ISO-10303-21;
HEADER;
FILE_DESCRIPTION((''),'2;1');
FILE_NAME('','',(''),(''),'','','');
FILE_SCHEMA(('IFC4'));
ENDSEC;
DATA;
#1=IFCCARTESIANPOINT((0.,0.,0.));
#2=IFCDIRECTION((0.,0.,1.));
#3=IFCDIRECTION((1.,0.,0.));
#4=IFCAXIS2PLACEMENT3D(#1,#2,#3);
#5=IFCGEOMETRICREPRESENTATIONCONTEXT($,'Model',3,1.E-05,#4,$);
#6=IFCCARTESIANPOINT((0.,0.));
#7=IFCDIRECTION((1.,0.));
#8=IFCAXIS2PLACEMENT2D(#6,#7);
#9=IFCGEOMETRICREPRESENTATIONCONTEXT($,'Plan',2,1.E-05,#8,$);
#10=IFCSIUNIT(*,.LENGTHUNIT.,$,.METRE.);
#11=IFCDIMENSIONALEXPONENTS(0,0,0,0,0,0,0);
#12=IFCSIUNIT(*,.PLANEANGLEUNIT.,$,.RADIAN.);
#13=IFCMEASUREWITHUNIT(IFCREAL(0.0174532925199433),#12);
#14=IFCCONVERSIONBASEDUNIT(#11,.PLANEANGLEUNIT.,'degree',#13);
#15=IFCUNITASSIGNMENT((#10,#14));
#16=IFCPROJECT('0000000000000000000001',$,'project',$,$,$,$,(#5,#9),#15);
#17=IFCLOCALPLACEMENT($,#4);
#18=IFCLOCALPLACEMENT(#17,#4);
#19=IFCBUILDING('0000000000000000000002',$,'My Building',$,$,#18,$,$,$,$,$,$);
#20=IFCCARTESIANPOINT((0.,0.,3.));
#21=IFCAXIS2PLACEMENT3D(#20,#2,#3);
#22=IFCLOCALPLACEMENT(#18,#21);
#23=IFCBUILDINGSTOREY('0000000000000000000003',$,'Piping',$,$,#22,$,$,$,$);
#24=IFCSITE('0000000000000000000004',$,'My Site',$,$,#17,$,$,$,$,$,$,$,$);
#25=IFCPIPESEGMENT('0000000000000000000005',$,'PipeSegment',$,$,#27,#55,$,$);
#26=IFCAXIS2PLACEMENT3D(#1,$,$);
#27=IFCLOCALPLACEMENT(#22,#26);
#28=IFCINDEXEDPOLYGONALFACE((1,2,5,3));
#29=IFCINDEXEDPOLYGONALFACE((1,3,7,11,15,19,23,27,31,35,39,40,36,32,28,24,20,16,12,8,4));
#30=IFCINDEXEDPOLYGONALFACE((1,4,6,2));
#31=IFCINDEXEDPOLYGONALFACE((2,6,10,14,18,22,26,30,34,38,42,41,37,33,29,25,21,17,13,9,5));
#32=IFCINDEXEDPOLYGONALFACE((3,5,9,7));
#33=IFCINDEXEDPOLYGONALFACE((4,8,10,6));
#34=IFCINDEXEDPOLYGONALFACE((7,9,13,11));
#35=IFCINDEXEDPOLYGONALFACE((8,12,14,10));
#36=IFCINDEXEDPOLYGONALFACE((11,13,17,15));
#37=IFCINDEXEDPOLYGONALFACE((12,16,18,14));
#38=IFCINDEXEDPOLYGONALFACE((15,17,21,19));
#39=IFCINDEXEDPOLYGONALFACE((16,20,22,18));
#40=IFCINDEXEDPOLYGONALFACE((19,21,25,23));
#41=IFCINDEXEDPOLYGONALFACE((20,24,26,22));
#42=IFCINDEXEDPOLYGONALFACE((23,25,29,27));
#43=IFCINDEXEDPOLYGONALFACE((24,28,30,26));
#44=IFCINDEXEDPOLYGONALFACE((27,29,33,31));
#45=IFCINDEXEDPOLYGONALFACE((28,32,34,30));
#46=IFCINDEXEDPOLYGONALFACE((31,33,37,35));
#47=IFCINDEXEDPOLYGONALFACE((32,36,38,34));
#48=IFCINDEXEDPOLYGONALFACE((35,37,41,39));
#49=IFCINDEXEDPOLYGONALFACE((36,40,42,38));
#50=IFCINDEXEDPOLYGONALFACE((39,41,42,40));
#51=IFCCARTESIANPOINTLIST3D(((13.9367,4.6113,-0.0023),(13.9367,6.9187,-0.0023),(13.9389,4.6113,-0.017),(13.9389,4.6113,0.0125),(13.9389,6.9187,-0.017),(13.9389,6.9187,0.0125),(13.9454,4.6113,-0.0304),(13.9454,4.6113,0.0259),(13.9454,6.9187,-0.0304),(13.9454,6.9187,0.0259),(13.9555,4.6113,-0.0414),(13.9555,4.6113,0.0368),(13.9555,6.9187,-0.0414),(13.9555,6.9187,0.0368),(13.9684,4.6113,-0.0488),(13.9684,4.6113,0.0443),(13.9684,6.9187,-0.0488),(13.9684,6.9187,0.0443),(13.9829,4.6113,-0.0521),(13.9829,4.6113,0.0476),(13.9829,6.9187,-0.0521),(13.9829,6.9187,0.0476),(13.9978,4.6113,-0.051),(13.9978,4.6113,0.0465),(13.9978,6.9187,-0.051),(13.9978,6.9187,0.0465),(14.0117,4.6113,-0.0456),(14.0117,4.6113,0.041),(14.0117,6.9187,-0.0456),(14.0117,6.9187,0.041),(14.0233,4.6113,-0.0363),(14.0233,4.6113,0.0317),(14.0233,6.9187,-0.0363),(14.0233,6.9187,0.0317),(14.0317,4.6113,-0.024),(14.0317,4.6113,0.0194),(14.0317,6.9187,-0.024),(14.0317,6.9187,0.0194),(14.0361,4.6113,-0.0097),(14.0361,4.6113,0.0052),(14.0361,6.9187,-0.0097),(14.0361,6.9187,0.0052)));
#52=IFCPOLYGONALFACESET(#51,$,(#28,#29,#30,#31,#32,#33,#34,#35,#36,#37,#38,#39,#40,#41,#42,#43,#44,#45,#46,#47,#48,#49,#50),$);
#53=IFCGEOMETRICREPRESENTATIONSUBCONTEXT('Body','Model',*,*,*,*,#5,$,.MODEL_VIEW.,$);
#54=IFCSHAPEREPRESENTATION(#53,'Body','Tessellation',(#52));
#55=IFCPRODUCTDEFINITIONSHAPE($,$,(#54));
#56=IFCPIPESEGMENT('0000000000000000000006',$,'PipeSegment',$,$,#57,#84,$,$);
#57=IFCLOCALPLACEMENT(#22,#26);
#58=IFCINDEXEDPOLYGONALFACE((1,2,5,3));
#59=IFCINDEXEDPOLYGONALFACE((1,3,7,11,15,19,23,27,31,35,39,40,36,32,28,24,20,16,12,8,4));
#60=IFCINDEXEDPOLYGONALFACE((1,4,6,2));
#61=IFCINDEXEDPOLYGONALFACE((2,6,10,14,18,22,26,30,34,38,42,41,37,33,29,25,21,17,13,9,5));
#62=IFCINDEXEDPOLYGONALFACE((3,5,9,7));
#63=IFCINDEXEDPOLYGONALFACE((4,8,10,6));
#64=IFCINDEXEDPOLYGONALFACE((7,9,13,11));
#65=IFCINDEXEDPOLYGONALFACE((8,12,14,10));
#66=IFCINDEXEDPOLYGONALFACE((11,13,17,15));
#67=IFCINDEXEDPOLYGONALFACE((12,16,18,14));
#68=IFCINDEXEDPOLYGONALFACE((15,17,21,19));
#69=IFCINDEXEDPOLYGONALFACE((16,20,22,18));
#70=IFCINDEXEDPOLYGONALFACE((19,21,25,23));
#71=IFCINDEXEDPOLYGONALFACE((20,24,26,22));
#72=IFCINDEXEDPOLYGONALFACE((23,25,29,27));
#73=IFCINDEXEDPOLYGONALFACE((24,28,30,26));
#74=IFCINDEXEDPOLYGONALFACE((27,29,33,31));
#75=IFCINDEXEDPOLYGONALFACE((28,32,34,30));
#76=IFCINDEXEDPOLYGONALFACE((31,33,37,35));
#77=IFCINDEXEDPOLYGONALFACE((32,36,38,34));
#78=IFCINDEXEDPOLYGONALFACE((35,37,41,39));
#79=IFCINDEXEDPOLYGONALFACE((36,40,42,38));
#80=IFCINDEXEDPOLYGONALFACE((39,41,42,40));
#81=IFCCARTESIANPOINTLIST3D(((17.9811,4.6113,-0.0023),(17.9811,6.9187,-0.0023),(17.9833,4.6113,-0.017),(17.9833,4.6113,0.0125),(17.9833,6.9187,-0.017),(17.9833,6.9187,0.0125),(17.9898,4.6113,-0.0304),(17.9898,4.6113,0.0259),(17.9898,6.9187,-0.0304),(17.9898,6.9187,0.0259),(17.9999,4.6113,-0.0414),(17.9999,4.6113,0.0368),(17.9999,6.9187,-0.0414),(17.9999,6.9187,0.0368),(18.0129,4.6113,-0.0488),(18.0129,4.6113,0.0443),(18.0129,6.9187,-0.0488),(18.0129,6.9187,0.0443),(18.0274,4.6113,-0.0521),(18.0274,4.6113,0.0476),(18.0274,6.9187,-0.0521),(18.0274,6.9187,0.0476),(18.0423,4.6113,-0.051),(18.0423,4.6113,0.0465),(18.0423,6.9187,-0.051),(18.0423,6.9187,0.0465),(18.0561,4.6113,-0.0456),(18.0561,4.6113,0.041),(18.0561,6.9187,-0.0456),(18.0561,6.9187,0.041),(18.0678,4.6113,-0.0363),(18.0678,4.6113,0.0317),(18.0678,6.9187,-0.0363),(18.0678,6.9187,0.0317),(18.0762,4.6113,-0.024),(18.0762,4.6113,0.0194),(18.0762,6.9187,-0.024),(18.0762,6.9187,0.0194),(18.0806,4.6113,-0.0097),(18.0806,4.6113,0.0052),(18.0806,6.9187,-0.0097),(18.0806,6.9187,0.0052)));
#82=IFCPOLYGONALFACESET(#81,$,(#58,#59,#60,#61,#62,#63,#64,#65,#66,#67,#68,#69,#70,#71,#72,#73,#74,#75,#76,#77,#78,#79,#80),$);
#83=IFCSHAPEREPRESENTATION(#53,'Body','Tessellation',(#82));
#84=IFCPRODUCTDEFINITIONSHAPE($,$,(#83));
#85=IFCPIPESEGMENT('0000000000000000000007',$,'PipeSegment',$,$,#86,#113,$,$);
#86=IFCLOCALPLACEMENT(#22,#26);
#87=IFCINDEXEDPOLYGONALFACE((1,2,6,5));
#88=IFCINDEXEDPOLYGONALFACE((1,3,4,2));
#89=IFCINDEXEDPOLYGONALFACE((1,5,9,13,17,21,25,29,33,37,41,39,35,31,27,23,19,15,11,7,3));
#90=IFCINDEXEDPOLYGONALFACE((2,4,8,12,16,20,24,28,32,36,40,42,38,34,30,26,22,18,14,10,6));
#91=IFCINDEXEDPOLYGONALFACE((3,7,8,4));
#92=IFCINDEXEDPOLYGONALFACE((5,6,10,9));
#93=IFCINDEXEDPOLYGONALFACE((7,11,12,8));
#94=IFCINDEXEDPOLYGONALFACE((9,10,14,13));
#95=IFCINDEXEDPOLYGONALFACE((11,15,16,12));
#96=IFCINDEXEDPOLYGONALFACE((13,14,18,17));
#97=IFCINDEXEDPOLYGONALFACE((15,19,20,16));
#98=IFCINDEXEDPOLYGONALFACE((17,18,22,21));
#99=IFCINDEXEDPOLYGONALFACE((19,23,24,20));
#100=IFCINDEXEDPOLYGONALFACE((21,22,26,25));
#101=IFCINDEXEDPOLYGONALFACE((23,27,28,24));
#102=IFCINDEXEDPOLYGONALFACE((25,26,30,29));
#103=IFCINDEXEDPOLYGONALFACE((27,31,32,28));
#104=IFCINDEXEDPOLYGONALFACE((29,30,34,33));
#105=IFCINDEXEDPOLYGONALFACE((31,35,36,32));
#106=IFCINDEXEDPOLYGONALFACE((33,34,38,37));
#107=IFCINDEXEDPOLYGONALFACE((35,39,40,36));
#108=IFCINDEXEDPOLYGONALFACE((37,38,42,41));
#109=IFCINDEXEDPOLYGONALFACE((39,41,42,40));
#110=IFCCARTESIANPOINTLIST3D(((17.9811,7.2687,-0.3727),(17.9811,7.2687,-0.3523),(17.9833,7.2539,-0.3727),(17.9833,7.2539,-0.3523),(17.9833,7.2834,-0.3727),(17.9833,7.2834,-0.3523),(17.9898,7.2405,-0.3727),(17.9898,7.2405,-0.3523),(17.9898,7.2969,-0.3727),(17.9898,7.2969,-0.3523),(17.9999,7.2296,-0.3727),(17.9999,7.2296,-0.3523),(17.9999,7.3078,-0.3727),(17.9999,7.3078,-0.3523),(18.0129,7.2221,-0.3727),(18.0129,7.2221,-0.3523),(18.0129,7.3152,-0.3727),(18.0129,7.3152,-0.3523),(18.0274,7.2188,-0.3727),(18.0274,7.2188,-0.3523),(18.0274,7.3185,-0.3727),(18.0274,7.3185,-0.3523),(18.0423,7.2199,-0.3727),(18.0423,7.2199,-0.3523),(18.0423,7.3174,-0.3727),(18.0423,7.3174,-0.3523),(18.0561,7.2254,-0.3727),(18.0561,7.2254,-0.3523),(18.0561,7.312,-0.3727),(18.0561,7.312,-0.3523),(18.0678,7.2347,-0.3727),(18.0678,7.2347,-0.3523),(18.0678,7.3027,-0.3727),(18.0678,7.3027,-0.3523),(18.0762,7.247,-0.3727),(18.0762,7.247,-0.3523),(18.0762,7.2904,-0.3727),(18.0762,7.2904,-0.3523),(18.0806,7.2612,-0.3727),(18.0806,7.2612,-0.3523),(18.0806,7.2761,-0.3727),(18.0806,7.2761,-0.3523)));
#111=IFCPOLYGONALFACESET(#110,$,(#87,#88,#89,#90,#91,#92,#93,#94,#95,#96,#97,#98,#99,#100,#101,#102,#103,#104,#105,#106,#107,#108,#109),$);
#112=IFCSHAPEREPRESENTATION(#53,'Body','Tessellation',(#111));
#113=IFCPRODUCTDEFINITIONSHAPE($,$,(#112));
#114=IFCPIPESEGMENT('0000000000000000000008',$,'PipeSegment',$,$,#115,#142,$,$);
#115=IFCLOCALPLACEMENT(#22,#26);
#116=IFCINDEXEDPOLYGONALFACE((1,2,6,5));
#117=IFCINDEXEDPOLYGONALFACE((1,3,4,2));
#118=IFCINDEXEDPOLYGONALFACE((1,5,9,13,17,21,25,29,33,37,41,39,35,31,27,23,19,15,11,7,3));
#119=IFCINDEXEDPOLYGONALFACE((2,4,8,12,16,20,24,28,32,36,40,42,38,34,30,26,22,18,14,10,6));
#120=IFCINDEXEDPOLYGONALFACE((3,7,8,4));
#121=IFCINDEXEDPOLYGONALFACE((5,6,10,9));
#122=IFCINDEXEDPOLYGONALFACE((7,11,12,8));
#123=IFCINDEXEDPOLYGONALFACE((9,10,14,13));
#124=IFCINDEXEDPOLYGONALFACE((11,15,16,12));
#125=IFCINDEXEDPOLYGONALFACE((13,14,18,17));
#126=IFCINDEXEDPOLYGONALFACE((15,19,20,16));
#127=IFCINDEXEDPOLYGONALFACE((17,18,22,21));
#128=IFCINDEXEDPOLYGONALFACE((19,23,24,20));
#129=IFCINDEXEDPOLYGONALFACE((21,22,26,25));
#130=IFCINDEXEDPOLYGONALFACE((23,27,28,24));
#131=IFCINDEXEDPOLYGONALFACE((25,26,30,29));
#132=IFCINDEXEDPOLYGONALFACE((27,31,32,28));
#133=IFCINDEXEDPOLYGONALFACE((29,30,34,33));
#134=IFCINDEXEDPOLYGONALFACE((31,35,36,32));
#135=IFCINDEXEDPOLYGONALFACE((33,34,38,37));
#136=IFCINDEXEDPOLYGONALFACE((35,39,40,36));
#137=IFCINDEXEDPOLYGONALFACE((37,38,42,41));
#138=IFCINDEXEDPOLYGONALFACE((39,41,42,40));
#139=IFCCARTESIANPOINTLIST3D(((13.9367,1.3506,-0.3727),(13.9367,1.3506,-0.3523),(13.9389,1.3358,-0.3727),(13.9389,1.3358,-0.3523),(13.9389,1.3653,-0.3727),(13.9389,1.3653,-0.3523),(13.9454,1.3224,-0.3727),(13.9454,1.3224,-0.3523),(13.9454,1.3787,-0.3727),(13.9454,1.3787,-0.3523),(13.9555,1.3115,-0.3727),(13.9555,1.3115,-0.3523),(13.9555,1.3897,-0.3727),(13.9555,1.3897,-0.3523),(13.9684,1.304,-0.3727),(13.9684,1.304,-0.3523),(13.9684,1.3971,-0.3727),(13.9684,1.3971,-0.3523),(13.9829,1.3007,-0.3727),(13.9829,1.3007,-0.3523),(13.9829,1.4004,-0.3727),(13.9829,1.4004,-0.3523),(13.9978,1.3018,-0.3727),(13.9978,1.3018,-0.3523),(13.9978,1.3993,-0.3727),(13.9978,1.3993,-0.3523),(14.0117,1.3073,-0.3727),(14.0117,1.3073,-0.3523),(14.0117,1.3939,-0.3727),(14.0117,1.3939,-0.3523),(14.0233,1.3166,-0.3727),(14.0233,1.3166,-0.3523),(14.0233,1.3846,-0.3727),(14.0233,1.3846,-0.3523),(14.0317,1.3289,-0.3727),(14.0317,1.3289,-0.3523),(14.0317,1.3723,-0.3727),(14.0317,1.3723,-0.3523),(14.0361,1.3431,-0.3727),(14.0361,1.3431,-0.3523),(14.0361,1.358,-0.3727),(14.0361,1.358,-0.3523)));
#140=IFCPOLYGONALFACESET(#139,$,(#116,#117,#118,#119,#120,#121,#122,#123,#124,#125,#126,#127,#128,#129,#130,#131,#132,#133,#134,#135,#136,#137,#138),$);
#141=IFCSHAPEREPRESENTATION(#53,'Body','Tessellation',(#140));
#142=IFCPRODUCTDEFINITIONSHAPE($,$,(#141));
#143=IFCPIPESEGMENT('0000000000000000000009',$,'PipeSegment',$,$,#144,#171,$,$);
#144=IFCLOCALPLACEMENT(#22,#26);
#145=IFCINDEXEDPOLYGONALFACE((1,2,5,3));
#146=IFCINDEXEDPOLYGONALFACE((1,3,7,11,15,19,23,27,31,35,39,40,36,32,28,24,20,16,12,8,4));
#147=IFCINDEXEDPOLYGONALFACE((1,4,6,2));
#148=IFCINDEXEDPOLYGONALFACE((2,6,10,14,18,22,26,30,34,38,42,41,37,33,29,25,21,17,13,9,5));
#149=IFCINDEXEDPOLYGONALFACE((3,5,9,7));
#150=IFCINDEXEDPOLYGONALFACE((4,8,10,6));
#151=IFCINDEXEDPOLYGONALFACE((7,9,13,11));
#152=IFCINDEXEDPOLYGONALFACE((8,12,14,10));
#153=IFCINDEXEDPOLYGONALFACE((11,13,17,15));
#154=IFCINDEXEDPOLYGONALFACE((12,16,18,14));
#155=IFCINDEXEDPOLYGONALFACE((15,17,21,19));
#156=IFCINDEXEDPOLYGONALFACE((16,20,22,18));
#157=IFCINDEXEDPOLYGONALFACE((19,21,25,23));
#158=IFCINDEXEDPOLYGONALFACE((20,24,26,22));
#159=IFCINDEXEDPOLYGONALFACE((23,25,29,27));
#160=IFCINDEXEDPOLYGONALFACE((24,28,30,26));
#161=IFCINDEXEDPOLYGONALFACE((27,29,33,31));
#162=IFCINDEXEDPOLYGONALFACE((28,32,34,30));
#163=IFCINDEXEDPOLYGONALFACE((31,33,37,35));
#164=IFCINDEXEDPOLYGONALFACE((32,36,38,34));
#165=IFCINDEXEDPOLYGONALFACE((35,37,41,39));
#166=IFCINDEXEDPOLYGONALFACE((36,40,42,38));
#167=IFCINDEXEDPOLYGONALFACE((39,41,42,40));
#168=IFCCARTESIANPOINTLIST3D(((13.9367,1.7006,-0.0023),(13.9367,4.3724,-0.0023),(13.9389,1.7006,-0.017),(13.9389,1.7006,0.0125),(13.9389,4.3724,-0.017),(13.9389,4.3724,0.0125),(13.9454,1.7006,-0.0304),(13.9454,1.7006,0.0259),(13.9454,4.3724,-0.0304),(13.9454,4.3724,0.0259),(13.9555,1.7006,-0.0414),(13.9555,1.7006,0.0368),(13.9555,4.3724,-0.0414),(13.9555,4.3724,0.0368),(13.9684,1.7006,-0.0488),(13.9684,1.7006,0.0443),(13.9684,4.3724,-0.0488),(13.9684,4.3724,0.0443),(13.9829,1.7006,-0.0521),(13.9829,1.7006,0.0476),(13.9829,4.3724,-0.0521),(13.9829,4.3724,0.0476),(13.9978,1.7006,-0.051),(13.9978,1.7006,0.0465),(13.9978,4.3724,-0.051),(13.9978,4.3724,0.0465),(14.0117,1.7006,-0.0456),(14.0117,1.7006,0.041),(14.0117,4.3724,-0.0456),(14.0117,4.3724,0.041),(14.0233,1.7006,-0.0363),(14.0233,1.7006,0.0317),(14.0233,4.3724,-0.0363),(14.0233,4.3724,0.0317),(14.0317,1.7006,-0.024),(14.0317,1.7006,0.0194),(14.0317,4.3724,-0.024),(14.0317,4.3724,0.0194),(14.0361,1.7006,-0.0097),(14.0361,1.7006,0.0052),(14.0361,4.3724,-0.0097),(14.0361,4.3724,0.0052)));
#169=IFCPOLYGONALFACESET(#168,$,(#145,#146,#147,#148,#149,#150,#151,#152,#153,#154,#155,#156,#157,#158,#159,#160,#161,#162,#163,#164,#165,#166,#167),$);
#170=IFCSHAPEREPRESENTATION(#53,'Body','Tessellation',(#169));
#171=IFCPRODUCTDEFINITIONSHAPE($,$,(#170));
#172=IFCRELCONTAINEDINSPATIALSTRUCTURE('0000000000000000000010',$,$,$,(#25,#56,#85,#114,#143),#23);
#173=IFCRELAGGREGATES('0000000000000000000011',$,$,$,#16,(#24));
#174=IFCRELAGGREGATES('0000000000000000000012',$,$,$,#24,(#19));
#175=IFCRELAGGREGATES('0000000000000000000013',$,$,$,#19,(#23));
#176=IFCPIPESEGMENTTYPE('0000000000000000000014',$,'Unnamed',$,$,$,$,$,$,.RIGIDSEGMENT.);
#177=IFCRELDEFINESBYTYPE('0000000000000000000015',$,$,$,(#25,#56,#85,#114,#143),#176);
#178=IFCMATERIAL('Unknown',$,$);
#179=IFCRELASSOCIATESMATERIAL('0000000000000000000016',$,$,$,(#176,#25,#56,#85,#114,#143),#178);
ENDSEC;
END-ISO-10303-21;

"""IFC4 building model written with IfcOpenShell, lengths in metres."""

from ifc_helpers import new_model, entity, si_unit, converted_unit, frame, origin_with_axes, origin_2d_with_axis, place, context, subcontext, project, spatial, circle, extrude, material, material_profile, profile_set, profile_usage, type_object, element, save


model = new_model("IFC4")

# Units and contexts
model_context = context("Model", 3, precision=1e-05, world=origin_with_axes())
plan_context = context("Plan", 2, precision=1e-05, world=origin_2d_with_axis())
body_context = subcontext(model_context, "Body", "Model", "MODEL_VIEW")
ifc_project = project(units=[si_unit("LENGTHUNIT", "METRE"), converted_unit("PLANEANGLEUNIT", "degree", entity("IfcReal", 0.0174532925199433), si_unit("PLANEANGLEUNIT", "RADIAN"), dimensions=[0, 0, 0, 0, 0, 0, 0])], contexts=[model_context, plan_context])

# Site, building, storey
site_placement = place(None, origin_with_axes())
site = spatial("IfcSite", under=ifc_project, at=site_placement, Name="My Site")
building_placement = place(site_placement, origin_with_axes())
building = spatial("IfcBuilding", under=site, at=building_placement, Name="My Building")
storey_placement = place(building_placement, frame((0.0, 0.0, 3.0), z_axis=(0.0, 0.0, 1.0), x_axis=(1.0, 0.0, 0.0)))
storey = spatial("IfcBuildingStorey", under=building, at=storey_placement, Name="Piping")

# Pipe segments
ifc_material = material(Name="Unknown")
ifc_material_profile_1 = material_profile(ifc_material, circle(Radius=0.05))
ifc_profile_set_1 = profile_set([ifc_material_profile_1])
pipe_segment_type = type_object("IfcPipeSegmentType", Name="Unnamed", PredefinedType="RIGIDSEGMENT", material=ifc_profile_set_1)
ifc_profile_usage_1 = profile_usage(ifc_profile_set_1, cardinal=5)
pipe_segment_1_placement = place(storey_placement, frame((13.9867, 4.6113, -0.0023), z_axis=(0.0, 1.0, 0.0), x_axis=(-1.0, 0.0, 0.0)))
element("IfcPipeSegment", 1, at=pipe_segment_1_placement, inside=storey, type_object=pipe_segment_type, material=ifc_profile_usage_1, Name="PipeSegment", context=body_context, shape_type="SweptSolid", body=[
    extrude(circle(Radius=0.05), origin_with_axes(), (0.0, 0.0, 1.0), 2.3074),
])
ifc_profile_usage_2 = profile_usage(ifc_profile_set_1, cardinal=5)
pipe_segment_2_placement = place(storey_placement, frame((18.0311, 4.6113, -0.0023), z_axis=(0.0, 1.0, 0.0), x_axis=(-1.0, 0.0, 0.0)))
element("IfcPipeSegment", 2, at=pipe_segment_2_placement, inside=storey, type_object=pipe_segment_type, material=ifc_profile_usage_2, Name="PipeSegment", context=body_context, shape_type="SweptSolid", body=[
    extrude(circle(Radius=0.05), origin_with_axes(), (0.0, 0.0, 1.0), 2.3074),
])
ifc_profile_usage_3 = profile_usage(ifc_profile_set_1, cardinal=5)
pipe_segment_3_placement = place(storey_placement, frame((18.0311, 7.2687, -0.3523), z_axis=(0.0, 0.0, -1.0), x_axis=(-1.0, 0.0, 0.0)))
element("IfcPipeSegment", 3, at=pipe_segment_3_placement, inside=storey, type_object=pipe_segment_type, material=ifc_profile_usage_3, Name="PipeSegment", context=body_context, shape_type="SweptSolid", body=[
    extrude(circle(Radius=0.05), origin_with_axes(), (0.0, 0.0, 1.0), 0.0204),
])
ifc_profile_usage_4 = profile_usage(ifc_profile_set_1, cardinal=5)
pipe_segment_4_placement = place(storey_placement, frame((13.9867, 1.3506, -0.3523), z_axis=(0.0, 0.0, -1.0), x_axis=(-1.0, 0.0, 0.0)))
element("IfcPipeSegment", 4, at=pipe_segment_4_placement, inside=storey, type_object=pipe_segment_type, material=ifc_profile_usage_4, Name="PipeSegment", context=body_context, shape_type="SweptSolid", body=[
    extrude(circle(Radius=0.05), origin_with_axes(), (0.0, 0.0, 1.0), 0.0204),
])
ifc_profile_usage_5 = profile_usage(ifc_profile_set_1, cardinal=5)
pipe_segment_5_placement = place(storey_placement, frame((13.9867, 1.7006, -0.0023), z_axis=(0.0, 1.0, 0.0), x_axis=(-1.0, 0.0, 0.0)))
element("IfcPipeSegment", 5, at=pipe_segment_5_placement, inside=storey, type_object=pipe_segment_type, material=ifc_profile_usage_5, Name="PipeSegment", context=body_context, shape_type="SweptSolid", body=[
    extrude(circle(Radius=0.05), origin_with_axes(), (0.0, 0.0, 1.0), 2.6719),
])

save(model, "model.ifc")
